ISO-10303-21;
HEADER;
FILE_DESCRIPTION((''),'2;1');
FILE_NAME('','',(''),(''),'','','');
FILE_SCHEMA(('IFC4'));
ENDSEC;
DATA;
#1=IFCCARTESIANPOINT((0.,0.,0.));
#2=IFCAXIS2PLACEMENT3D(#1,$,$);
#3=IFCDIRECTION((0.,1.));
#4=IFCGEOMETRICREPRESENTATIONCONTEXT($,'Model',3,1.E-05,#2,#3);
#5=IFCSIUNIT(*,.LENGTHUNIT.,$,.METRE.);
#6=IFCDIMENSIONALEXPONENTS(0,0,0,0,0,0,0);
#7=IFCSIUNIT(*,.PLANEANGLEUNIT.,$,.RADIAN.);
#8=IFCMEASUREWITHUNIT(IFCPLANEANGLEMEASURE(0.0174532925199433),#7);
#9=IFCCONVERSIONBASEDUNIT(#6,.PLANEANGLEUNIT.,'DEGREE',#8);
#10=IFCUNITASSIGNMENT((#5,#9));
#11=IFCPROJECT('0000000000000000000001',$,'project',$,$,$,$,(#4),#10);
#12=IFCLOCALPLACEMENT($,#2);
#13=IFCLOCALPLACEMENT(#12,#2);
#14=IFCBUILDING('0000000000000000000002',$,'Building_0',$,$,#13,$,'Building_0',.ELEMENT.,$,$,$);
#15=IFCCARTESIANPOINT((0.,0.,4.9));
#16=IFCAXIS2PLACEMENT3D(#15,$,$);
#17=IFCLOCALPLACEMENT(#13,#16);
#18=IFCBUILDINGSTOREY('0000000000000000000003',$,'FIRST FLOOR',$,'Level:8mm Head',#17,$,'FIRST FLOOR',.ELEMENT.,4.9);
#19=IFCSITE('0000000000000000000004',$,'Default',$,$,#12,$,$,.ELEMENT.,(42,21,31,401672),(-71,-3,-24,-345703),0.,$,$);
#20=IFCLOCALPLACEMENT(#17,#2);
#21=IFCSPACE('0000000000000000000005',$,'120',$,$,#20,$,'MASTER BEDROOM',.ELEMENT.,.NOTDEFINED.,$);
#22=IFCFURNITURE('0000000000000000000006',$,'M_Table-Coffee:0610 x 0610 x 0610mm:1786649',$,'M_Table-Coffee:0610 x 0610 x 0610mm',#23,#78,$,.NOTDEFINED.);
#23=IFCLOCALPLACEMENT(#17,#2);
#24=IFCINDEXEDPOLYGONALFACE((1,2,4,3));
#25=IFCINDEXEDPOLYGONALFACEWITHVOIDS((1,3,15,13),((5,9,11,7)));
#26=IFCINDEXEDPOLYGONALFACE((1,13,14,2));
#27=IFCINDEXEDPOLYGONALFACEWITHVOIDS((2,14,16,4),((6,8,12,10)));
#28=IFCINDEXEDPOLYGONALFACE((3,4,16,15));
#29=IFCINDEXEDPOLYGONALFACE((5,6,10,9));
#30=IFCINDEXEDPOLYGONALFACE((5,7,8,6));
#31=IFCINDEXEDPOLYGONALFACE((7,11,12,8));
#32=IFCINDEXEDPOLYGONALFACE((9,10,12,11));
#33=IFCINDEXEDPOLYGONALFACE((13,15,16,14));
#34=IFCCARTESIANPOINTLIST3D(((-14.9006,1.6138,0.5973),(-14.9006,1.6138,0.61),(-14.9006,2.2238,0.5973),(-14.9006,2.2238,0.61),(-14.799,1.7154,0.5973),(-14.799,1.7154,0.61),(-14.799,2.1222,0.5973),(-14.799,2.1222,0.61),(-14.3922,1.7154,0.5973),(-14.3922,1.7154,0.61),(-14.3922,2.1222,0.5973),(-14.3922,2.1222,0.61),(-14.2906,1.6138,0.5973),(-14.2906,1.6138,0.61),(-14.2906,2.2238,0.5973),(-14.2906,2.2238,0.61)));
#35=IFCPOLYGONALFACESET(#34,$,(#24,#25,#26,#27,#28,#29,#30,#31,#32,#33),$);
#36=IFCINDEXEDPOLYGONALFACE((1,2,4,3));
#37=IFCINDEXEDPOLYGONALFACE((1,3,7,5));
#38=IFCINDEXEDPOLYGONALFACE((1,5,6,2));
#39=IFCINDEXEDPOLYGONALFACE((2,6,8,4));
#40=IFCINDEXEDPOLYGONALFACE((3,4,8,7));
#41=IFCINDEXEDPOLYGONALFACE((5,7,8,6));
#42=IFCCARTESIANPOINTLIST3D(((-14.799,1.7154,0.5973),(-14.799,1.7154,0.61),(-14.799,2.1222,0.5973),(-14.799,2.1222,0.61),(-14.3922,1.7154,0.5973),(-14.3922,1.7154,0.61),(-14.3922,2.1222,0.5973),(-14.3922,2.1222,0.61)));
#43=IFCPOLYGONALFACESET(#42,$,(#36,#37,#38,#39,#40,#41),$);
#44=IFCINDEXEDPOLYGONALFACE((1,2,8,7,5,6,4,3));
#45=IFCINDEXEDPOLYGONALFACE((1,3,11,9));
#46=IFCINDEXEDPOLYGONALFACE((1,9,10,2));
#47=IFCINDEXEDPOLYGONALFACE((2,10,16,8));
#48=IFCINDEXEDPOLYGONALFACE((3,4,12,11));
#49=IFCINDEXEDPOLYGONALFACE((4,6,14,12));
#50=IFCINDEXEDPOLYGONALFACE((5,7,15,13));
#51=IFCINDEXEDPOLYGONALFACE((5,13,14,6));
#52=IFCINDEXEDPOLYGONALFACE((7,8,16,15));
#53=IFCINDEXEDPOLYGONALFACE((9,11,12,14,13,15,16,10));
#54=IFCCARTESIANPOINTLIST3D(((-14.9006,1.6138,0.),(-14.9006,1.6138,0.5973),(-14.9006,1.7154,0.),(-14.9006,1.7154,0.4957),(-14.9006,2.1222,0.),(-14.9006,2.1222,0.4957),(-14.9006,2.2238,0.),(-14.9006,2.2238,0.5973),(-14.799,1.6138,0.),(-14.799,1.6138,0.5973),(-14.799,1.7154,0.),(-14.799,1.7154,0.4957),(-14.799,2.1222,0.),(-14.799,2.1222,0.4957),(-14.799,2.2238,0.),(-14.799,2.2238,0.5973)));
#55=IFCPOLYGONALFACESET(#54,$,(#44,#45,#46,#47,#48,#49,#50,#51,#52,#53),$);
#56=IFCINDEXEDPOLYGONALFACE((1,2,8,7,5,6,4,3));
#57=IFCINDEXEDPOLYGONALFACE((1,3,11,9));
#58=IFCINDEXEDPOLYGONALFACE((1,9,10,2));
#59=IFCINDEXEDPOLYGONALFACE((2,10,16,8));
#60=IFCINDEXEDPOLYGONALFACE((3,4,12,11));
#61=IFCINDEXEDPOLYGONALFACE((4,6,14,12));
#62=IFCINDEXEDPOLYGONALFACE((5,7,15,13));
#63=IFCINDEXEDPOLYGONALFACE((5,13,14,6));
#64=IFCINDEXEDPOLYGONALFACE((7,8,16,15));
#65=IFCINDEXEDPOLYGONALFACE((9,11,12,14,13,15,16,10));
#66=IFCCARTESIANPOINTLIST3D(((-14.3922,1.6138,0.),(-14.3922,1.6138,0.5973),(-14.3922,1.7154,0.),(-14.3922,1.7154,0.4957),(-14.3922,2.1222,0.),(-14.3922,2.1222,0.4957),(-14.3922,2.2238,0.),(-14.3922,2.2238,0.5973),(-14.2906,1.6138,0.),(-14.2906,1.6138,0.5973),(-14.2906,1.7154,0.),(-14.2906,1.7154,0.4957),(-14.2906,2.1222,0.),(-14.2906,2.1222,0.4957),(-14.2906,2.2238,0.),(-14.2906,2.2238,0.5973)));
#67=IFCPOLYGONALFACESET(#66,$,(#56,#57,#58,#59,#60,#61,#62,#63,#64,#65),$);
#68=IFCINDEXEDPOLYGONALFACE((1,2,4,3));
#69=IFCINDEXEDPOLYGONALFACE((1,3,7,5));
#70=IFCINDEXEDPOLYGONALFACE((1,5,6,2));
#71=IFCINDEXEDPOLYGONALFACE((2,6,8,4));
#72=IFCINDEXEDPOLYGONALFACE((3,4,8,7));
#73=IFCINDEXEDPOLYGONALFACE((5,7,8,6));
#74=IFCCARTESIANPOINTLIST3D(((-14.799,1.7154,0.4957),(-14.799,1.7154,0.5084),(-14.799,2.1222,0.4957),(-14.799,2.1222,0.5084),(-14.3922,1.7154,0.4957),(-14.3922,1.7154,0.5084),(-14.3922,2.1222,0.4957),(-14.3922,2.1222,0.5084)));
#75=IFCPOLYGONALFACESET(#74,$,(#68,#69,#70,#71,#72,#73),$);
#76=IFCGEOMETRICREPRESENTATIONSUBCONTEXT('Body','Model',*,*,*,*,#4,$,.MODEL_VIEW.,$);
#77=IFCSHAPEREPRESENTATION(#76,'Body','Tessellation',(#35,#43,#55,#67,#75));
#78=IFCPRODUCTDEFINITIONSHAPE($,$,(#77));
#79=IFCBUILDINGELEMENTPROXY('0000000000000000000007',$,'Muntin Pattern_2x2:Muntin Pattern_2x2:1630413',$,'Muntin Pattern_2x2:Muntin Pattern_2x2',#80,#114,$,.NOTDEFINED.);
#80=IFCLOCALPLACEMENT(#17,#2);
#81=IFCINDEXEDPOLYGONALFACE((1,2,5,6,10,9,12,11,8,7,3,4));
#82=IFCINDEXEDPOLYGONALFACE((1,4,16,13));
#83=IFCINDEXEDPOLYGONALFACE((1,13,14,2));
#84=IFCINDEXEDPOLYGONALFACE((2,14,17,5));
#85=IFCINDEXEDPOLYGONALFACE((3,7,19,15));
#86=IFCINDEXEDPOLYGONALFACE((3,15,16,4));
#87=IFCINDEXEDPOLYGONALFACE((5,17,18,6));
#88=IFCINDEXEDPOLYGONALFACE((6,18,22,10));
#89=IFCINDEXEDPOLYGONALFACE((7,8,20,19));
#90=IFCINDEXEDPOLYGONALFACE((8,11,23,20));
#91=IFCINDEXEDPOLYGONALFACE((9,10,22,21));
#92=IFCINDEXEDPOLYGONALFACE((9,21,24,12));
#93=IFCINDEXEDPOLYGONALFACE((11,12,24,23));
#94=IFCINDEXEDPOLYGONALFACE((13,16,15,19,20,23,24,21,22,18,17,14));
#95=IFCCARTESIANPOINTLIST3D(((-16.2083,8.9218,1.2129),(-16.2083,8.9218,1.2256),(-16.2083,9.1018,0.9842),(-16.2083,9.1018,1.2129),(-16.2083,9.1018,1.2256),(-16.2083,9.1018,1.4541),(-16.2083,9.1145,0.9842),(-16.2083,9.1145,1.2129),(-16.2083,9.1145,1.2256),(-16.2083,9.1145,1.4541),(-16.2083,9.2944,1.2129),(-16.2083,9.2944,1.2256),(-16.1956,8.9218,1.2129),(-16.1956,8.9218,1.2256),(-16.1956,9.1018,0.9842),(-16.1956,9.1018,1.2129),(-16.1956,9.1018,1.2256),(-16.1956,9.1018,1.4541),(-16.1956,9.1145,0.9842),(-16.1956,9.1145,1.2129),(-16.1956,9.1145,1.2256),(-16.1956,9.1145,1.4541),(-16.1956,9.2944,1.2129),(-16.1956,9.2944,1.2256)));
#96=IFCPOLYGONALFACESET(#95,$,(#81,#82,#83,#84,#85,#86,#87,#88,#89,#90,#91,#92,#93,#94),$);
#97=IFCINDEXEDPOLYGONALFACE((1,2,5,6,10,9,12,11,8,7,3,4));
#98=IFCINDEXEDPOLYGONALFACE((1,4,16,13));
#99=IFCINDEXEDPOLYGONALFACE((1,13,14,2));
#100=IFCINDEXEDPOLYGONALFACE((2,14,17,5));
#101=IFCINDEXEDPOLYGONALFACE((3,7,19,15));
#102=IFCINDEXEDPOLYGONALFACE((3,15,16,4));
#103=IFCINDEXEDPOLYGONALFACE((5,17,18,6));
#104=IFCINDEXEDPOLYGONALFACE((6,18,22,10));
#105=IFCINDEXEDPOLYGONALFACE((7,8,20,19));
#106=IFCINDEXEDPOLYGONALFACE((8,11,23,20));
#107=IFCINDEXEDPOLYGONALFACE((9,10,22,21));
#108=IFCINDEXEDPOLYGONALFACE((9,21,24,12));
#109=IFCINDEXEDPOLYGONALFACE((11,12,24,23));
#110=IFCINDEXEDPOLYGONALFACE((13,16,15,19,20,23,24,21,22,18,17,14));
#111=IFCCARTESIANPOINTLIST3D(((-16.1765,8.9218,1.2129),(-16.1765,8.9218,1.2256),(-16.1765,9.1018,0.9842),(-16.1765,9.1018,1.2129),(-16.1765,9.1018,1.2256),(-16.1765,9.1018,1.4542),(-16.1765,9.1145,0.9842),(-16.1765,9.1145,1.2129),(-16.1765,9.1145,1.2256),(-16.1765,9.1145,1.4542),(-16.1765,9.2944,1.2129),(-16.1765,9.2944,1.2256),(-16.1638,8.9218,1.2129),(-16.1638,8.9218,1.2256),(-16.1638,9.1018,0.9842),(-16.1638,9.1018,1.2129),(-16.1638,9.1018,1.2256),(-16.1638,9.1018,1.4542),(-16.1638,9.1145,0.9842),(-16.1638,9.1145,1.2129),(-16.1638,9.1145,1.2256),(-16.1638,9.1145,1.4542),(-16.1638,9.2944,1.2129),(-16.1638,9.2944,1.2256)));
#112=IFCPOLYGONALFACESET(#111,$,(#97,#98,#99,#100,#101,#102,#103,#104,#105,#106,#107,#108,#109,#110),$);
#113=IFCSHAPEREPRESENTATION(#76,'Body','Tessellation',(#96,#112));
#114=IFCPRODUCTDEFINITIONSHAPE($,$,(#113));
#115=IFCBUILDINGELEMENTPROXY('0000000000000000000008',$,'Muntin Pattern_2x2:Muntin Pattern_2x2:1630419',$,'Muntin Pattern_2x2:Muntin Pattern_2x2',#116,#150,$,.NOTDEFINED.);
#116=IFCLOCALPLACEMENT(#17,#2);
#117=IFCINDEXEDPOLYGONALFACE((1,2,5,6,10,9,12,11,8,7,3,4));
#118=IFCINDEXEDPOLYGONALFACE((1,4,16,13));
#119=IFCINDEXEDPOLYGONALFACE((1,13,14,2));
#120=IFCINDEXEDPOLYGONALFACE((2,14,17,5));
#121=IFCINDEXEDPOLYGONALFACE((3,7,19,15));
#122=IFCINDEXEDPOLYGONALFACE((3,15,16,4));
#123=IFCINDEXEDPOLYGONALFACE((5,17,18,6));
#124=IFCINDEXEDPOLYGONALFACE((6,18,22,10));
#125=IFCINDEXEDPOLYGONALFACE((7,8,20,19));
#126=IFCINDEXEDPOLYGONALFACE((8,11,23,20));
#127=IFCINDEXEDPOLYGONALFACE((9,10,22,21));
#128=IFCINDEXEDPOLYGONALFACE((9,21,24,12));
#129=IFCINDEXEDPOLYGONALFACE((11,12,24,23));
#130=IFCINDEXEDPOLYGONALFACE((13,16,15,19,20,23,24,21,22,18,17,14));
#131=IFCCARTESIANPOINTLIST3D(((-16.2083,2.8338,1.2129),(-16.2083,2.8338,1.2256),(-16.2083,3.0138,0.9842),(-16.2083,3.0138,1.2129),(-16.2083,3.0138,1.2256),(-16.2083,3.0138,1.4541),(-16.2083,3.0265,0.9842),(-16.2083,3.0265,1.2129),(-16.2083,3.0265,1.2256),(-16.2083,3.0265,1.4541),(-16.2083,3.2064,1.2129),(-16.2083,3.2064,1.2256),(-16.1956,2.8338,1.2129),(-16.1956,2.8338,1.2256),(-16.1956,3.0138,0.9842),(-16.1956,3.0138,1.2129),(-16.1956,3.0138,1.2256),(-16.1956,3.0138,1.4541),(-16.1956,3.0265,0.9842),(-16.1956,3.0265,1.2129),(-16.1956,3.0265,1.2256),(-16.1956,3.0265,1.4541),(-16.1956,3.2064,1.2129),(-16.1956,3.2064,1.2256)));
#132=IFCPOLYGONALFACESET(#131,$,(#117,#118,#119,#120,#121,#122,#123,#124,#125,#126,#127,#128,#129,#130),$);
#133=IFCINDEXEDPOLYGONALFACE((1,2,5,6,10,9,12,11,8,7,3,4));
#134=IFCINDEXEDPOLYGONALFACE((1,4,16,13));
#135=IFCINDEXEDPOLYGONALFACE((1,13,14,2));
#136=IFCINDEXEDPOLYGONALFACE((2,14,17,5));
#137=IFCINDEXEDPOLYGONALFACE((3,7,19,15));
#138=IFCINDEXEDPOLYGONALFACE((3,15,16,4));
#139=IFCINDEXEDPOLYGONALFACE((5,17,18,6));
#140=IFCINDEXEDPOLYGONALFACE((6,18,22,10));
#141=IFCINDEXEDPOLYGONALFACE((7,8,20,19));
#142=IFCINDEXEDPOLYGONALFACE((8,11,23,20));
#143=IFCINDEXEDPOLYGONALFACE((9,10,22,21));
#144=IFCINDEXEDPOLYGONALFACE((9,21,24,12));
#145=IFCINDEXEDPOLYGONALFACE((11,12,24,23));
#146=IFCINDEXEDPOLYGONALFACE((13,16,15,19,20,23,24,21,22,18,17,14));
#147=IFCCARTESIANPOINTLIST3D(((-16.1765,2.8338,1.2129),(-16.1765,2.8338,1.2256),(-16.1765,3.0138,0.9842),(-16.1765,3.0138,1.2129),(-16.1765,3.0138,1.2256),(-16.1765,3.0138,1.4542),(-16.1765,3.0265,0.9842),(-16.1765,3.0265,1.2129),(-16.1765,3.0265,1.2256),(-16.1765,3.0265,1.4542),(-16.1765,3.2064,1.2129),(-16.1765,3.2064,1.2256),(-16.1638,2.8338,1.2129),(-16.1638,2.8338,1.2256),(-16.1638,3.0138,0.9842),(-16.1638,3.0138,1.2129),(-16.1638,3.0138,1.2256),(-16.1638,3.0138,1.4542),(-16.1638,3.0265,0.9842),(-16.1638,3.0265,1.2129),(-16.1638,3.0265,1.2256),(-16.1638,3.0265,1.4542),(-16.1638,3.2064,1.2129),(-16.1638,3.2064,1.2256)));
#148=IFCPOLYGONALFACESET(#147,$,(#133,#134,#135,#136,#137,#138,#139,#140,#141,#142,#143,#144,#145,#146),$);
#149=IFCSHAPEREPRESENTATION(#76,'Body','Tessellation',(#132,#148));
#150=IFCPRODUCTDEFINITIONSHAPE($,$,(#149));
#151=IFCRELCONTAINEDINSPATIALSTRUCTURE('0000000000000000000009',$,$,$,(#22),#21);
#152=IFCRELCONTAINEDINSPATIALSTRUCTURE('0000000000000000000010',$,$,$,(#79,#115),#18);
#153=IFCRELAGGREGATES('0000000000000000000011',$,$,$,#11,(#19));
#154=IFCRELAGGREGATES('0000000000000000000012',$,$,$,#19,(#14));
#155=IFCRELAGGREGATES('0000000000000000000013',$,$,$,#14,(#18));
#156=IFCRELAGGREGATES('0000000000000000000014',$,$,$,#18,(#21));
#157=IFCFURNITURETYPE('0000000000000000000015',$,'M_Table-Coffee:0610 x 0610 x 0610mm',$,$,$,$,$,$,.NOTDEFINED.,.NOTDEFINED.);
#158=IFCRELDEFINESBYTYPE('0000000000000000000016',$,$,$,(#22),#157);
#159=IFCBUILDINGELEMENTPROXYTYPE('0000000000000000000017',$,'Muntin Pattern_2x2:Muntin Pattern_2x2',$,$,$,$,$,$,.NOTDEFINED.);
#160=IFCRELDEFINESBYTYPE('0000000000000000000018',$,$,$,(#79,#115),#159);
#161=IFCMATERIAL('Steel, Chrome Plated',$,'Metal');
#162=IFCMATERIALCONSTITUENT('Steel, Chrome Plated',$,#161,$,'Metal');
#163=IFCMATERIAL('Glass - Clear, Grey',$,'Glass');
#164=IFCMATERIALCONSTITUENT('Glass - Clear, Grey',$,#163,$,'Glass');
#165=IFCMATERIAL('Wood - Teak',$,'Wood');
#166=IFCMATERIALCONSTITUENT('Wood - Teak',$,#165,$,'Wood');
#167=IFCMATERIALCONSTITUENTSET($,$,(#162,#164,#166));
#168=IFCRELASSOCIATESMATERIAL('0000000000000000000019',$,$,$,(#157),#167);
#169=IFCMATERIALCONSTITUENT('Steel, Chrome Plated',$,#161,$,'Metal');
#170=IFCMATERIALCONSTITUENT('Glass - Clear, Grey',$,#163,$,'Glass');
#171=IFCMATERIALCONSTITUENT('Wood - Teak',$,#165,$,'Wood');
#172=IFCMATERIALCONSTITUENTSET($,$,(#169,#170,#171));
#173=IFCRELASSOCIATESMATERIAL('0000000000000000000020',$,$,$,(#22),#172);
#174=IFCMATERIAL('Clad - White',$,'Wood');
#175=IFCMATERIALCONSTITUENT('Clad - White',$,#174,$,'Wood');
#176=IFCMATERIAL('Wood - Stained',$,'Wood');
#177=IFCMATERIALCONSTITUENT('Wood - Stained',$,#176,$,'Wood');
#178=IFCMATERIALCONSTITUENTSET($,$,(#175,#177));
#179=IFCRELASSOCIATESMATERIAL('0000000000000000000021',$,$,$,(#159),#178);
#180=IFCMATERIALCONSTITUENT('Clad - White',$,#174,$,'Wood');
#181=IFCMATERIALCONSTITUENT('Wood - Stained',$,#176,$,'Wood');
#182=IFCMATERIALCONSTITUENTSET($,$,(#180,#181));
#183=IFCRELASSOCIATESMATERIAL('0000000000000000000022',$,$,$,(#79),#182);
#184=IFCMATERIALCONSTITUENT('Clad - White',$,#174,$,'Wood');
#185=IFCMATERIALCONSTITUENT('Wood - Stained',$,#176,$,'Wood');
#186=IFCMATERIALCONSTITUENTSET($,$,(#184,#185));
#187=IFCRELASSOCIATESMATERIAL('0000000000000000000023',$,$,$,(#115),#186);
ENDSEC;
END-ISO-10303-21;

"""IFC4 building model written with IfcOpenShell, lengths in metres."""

from ifc_helpers import new_model, entity, si_unit, converted_unit, direction, frame, origin, place, context, subcontext, project, spatial, indexed_curve, outline, extrude, source, transform, mapped, material, constituent, constituent_set, type_object, type_shapes, element, save


model = new_model("IFC4")

# Units and contexts
model_context = context("Model", 3, precision=1e-05, world=origin(), true_north=direction((0.0, 1.0)))
body_context = subcontext(model_context, "Body", "Model", "MODEL_VIEW")
ifc_project = project(units=[si_unit("LENGTHUNIT", "METRE"), converted_unit("PLANEANGLEUNIT", "DEGREE", entity("IfcPlaneAngleMeasure", 0.0174532925199433), si_unit("PLANEANGLEUNIT", "RADIAN"), dimensions=[0, 0, 0, 0, 0, 0, 0])], contexts=[model_context])

# Site, building, storey
site_placement = place(None, origin())
site = spatial("IfcSite", under=ifc_project, at=site_placement, Name="Default", CompositionType="ELEMENT", RefLatitude=(42, 21, 31, 401672), RefLongitude=(-71, -3, -24, -345703), RefElevation=0.0)
building_placement = place(site_placement, origin())
building = spatial("IfcBuilding", under=site, at=building_placement, Name="Building_0", LongName="Building_0", CompositionType="ELEMENT")
storey_placement = place(building_placement, frame((0.0, 0.0, 4.9)))
storey = spatial("IfcBuildingStorey", under=building, at=storey_placement, Name="FIRST FLOOR", ObjectType="Level:8mm Head", LongName="FIRST FLOOR", CompositionType="ELEMENT", Elevation=4.9)

# Shared definitions
ifc_material_1 = material(Name="Clad - White", Category="Wood")

# Shared definitions
space_1_placement = place(storey_placement, origin())
space_1 = spatial("IfcSpace", under=storey, at=space_1_placement, Name="120", LongName="MASTER BEDROOM", CompositionType="ELEMENT", PredefinedType="NOTDEFINED")

# Furniture
ifc_material_2 = material(Name="Steel, Chrome Plated", Category="Metal")
ifc_constituent_1 = constituent(ifc_material_2, Name="Steel, Chrome Plated", Category="Metal")
ifc_material_3 = material(Name="Glass - Clear, Grey", Category="Glass")
ifc_constituent_2 = constituent(ifc_material_3, Name="Glass - Clear, Grey", Category="Glass")
ifc_material_4 = material(Name="Wood - Teak", Category="Wood")
ifc_constituent_3 = constituent(ifc_material_4, Name="Wood - Teak", Category="Wood")
ifc_constituent_set_1 = constituent_set(constituents=[ifc_constituent_1, ifc_constituent_2, ifc_constituent_3])
ifc_constituent_4 = constituent(ifc_material_2, Name="Steel, Chrome Plated", Category="Metal")
ifc_constituent_5 = constituent(ifc_material_3, Name="Glass - Clear, Grey", Category="Glass")
ifc_constituent_6 = constituent(ifc_material_4, Name="Wood - Teak", Category="Wood")
ifc_constituent_set_2 = constituent_set(constituents=[ifc_constituent_4, ifc_constituent_5, ifc_constituent_6])
furniture_type = type_object("IfcFurnitureType", Name="M_Table-Coffee:0610 x 0610 x 0610mm", AssemblyPlace="NOTDEFINED", PredefinedType="NOTDEFINED", material=ifc_constituent_set_2)
shared_shape_1 = source(origin(), body_context, "Body", "SweptSolid", [
    extrude(outline(indexed_curve([(-0.305, -0.305), (0.305, -0.305), (0.305, 0.305), (-0.305, 0.305), (-0.305, -0.305)], self_intersect=False), holes=[indexed_curve([(-0.2034, -0.2034), (-0.2034, 0.2034), (0.2034, 0.2034), (0.2034, -0.2034), (-0.2034, -0.2034)], self_intersect=False)]), frame((0.0183, 0.0952, 0.5973), z_axis=(0.0, 0.0, 1.0), x_axis=(-1.0, 0.0, 0.0)), (0.0, 0.0, 1.0), 0.0127),
    extrude(outline(indexed_curve([(-0.2034, -0.2034), (0.2034, -0.2034), (0.2034, 0.2034), (-0.2034, 0.2034), (-0.2034, -0.2034)], self_intersect=False)), frame((0.0183, 0.0952, 0.5973), z_axis=(0.0, 0.0, 1.0), x_axis=(-1.0, 0.0, 0.0)), (0.0, 0.0, 1.0), 0.0127),
    extrude(outline(indexed_curve([(-0.305, -0.3241), (0.305, -0.3241), (0.305, 0.2733), (0.2034, 0.2733), (0.2034, -0.2224), (-0.2034, -0.2224), (-0.2034, 0.2733), (-0.305, 0.2733), (-0.305, -0.3241)], self_intersect=False)), frame((-0.2867, 0.0952, 0.2733), z_axis=(1.0, 0.0, 0.0), x_axis=(0.0, -1.0, 0.0)), (0.0, 0.0, 1.0), 0.1016),
    extrude(outline(indexed_curve([(-0.2732, -0.305), (0.324, -0.305), (0.324, 0.305), (-0.2732, 0.305), (-0.2732, 0.2034), (0.2225, 0.2034), (0.2225, -0.2034), (-0.2732, -0.2034), (-0.2732, -0.305)], self_intersect=False)), frame((0.2217, 0.0952, 0.2732), z_axis=(1.0, 0.0, 0.0), x_axis=(0.0, 0.0, 1.0)), (0.0, 0.0, 1.0), 0.1016),
    extrude(outline(indexed_curve([(-0.2034, -0.2034), (0.2034, -0.2034), (0.2034, 0.2034), (-0.2034, 0.2034), (-0.2034, -0.2034)], self_intersect=False)), frame((0.0183, 0.0952, 0.4957), z_axis=(0.0, 0.0, 1.0), x_axis=(-1.0, 0.0, 0.0)), (0.0, 0.0, 1.0), 0.0127),
])
type_shapes(furniture_type, [shared_shape_1])
furniture_placement = place(space_1_placement, frame((-14.6139, 1.8236, 0.0)))
element("IfcFurniture", 1, at=furniture_placement, inside=space_1, type_object=furniture_type, material=ifc_constituent_set_1, Name="M_Table-Coffee:0610 x 0610 x 0610mm:1786649", ObjectType="M_Table-Coffee:0610 x 0610 x 0610mm", PredefinedType="NOTDEFINED", context=body_context, shape_type="MappedRepresentation", body=[
    mapped(shared_shape_1, transform((0.0, 0.0, 0.0), scale=1.0)),
])

# Building element proxies
ifc_constituent_7 = constituent(ifc_material_1, Name="Clad - White", Category="Wood")
ifc_material_5 = material(Name="Wood - Stained", Category="Wood")
ifc_constituent_8 = constituent(ifc_material_5, Name="Wood - Stained", Category="Wood")
ifc_constituent_set_3 = constituent_set(constituents=[ifc_constituent_7, ifc_constituent_8])
ifc_constituent_9 = constituent(ifc_material_1, Name="Clad - White", Category="Wood")
ifc_constituent_10 = constituent(ifc_material_5, Name="Wood - Stained", Category="Wood")
ifc_constituent_set_4 = constituent_set(constituents=[ifc_constituent_9, ifc_constituent_10])
building_element_proxy_type_1 = type_object("IfcBuildingElementProxyType", Name="Muntin Pattern_2x2:Muntin Pattern_2x2", PredefinedType="NOTDEFINED", material=ifc_constituent_set_4)
shared_shape_2 = source(origin(), body_context, "Body", "SweptSolid", [
    extrude(outline(indexed_curve([(0.0064, -0.0064), (0.2349, -0.0064), (0.2349, 0.0063), (0.0064, 0.0063), (0.0064, 0.1863), (-0.0063, 0.1863), (-0.0063, 0.0063), (-0.235, 0.0063), (-0.235, -0.0064), (-0.0063, -0.0064), (-0.0063, -0.1863), (0.0064, -0.1863), (0.0064, -0.0064)], self_intersect=False)), frame((0.0, 0.0095, 0.235), z_axis=(0.0, 1.0, 0.0), x_axis=(0.0, 0.0, 1.0)), (0.0, 0.0, 1.0), 0.0127),
    extrude(outline(indexed_curve([(0.0064, -0.0064), (0.235, -0.0064), (0.235, 0.0063), (0.0064, 0.0063), (0.0064, 0.1863), (-0.0063, 0.1863), (-0.0063, 0.0063), (-0.235, 0.0063), (-0.235, -0.0064), (-0.0063, -0.0064), (-0.0063, -0.1863), (0.0064, -0.1863), (0.0064, -0.0064)], self_intersect=False)), frame((0.0, -0.0222, 0.235), z_axis=(0.0, 1.0, 0.0), x_axis=(0.0, 0.0, 1.0)), (0.0, 0.0, 1.0), 0.0127),
])
type_shapes(building_element_proxy_type_1, [shared_shape_2])
proxy_1_placement = place(storey_placement, frame((-16.1861, 9.1081, 0.9842), z_axis=(0.0, 0.0, 1.0), x_axis=(0.0, 1.0, 0.0)))
element("IfcBuildingElementProxy", 2, at=proxy_1_placement, inside=storey, type_object=building_element_proxy_type_1, material=ifc_constituent_set_3, Name="Muntin Pattern_2x2:Muntin Pattern_2x2:1630413", ObjectType="Muntin Pattern_2x2:Muntin Pattern_2x2", PredefinedType="NOTDEFINED", context=body_context, shape_type="MappedRepresentation", body=[
    mapped(shared_shape_2, transform((0.0, 0.0, 0.0), scale=1.0)),
])
ifc_constituent_11 = constituent(ifc_material_1, Name="Clad - White", Category="Wood")
ifc_constituent_12 = constituent(ifc_material_5, Name="Wood - Stained", Category="Wood")
ifc_constituent_set_5 = constituent_set(constituents=[ifc_constituent_11, ifc_constituent_12])
proxy_2_placement = place(storey_placement, frame((-16.1861, 3.0201, 0.9842), z_axis=(0.0, 0.0, 1.0), x_axis=(0.0, 1.0, 0.0)))
element("IfcBuildingElementProxy", 3, at=proxy_2_placement, inside=storey, type_object=building_element_proxy_type_1, material=ifc_constituent_set_5, Name="Muntin Pattern_2x2:Muntin Pattern_2x2:1630419", ObjectType="Muntin Pattern_2x2:Muntin Pattern_2x2", PredefinedType="NOTDEFINED", context=body_context, shape_type="MappedRepresentation", body=[
    mapped(shared_shape_2, transform((0.0, 0.0, 0.0), scale=1.0)),
])

save(model, "model.ifc")
